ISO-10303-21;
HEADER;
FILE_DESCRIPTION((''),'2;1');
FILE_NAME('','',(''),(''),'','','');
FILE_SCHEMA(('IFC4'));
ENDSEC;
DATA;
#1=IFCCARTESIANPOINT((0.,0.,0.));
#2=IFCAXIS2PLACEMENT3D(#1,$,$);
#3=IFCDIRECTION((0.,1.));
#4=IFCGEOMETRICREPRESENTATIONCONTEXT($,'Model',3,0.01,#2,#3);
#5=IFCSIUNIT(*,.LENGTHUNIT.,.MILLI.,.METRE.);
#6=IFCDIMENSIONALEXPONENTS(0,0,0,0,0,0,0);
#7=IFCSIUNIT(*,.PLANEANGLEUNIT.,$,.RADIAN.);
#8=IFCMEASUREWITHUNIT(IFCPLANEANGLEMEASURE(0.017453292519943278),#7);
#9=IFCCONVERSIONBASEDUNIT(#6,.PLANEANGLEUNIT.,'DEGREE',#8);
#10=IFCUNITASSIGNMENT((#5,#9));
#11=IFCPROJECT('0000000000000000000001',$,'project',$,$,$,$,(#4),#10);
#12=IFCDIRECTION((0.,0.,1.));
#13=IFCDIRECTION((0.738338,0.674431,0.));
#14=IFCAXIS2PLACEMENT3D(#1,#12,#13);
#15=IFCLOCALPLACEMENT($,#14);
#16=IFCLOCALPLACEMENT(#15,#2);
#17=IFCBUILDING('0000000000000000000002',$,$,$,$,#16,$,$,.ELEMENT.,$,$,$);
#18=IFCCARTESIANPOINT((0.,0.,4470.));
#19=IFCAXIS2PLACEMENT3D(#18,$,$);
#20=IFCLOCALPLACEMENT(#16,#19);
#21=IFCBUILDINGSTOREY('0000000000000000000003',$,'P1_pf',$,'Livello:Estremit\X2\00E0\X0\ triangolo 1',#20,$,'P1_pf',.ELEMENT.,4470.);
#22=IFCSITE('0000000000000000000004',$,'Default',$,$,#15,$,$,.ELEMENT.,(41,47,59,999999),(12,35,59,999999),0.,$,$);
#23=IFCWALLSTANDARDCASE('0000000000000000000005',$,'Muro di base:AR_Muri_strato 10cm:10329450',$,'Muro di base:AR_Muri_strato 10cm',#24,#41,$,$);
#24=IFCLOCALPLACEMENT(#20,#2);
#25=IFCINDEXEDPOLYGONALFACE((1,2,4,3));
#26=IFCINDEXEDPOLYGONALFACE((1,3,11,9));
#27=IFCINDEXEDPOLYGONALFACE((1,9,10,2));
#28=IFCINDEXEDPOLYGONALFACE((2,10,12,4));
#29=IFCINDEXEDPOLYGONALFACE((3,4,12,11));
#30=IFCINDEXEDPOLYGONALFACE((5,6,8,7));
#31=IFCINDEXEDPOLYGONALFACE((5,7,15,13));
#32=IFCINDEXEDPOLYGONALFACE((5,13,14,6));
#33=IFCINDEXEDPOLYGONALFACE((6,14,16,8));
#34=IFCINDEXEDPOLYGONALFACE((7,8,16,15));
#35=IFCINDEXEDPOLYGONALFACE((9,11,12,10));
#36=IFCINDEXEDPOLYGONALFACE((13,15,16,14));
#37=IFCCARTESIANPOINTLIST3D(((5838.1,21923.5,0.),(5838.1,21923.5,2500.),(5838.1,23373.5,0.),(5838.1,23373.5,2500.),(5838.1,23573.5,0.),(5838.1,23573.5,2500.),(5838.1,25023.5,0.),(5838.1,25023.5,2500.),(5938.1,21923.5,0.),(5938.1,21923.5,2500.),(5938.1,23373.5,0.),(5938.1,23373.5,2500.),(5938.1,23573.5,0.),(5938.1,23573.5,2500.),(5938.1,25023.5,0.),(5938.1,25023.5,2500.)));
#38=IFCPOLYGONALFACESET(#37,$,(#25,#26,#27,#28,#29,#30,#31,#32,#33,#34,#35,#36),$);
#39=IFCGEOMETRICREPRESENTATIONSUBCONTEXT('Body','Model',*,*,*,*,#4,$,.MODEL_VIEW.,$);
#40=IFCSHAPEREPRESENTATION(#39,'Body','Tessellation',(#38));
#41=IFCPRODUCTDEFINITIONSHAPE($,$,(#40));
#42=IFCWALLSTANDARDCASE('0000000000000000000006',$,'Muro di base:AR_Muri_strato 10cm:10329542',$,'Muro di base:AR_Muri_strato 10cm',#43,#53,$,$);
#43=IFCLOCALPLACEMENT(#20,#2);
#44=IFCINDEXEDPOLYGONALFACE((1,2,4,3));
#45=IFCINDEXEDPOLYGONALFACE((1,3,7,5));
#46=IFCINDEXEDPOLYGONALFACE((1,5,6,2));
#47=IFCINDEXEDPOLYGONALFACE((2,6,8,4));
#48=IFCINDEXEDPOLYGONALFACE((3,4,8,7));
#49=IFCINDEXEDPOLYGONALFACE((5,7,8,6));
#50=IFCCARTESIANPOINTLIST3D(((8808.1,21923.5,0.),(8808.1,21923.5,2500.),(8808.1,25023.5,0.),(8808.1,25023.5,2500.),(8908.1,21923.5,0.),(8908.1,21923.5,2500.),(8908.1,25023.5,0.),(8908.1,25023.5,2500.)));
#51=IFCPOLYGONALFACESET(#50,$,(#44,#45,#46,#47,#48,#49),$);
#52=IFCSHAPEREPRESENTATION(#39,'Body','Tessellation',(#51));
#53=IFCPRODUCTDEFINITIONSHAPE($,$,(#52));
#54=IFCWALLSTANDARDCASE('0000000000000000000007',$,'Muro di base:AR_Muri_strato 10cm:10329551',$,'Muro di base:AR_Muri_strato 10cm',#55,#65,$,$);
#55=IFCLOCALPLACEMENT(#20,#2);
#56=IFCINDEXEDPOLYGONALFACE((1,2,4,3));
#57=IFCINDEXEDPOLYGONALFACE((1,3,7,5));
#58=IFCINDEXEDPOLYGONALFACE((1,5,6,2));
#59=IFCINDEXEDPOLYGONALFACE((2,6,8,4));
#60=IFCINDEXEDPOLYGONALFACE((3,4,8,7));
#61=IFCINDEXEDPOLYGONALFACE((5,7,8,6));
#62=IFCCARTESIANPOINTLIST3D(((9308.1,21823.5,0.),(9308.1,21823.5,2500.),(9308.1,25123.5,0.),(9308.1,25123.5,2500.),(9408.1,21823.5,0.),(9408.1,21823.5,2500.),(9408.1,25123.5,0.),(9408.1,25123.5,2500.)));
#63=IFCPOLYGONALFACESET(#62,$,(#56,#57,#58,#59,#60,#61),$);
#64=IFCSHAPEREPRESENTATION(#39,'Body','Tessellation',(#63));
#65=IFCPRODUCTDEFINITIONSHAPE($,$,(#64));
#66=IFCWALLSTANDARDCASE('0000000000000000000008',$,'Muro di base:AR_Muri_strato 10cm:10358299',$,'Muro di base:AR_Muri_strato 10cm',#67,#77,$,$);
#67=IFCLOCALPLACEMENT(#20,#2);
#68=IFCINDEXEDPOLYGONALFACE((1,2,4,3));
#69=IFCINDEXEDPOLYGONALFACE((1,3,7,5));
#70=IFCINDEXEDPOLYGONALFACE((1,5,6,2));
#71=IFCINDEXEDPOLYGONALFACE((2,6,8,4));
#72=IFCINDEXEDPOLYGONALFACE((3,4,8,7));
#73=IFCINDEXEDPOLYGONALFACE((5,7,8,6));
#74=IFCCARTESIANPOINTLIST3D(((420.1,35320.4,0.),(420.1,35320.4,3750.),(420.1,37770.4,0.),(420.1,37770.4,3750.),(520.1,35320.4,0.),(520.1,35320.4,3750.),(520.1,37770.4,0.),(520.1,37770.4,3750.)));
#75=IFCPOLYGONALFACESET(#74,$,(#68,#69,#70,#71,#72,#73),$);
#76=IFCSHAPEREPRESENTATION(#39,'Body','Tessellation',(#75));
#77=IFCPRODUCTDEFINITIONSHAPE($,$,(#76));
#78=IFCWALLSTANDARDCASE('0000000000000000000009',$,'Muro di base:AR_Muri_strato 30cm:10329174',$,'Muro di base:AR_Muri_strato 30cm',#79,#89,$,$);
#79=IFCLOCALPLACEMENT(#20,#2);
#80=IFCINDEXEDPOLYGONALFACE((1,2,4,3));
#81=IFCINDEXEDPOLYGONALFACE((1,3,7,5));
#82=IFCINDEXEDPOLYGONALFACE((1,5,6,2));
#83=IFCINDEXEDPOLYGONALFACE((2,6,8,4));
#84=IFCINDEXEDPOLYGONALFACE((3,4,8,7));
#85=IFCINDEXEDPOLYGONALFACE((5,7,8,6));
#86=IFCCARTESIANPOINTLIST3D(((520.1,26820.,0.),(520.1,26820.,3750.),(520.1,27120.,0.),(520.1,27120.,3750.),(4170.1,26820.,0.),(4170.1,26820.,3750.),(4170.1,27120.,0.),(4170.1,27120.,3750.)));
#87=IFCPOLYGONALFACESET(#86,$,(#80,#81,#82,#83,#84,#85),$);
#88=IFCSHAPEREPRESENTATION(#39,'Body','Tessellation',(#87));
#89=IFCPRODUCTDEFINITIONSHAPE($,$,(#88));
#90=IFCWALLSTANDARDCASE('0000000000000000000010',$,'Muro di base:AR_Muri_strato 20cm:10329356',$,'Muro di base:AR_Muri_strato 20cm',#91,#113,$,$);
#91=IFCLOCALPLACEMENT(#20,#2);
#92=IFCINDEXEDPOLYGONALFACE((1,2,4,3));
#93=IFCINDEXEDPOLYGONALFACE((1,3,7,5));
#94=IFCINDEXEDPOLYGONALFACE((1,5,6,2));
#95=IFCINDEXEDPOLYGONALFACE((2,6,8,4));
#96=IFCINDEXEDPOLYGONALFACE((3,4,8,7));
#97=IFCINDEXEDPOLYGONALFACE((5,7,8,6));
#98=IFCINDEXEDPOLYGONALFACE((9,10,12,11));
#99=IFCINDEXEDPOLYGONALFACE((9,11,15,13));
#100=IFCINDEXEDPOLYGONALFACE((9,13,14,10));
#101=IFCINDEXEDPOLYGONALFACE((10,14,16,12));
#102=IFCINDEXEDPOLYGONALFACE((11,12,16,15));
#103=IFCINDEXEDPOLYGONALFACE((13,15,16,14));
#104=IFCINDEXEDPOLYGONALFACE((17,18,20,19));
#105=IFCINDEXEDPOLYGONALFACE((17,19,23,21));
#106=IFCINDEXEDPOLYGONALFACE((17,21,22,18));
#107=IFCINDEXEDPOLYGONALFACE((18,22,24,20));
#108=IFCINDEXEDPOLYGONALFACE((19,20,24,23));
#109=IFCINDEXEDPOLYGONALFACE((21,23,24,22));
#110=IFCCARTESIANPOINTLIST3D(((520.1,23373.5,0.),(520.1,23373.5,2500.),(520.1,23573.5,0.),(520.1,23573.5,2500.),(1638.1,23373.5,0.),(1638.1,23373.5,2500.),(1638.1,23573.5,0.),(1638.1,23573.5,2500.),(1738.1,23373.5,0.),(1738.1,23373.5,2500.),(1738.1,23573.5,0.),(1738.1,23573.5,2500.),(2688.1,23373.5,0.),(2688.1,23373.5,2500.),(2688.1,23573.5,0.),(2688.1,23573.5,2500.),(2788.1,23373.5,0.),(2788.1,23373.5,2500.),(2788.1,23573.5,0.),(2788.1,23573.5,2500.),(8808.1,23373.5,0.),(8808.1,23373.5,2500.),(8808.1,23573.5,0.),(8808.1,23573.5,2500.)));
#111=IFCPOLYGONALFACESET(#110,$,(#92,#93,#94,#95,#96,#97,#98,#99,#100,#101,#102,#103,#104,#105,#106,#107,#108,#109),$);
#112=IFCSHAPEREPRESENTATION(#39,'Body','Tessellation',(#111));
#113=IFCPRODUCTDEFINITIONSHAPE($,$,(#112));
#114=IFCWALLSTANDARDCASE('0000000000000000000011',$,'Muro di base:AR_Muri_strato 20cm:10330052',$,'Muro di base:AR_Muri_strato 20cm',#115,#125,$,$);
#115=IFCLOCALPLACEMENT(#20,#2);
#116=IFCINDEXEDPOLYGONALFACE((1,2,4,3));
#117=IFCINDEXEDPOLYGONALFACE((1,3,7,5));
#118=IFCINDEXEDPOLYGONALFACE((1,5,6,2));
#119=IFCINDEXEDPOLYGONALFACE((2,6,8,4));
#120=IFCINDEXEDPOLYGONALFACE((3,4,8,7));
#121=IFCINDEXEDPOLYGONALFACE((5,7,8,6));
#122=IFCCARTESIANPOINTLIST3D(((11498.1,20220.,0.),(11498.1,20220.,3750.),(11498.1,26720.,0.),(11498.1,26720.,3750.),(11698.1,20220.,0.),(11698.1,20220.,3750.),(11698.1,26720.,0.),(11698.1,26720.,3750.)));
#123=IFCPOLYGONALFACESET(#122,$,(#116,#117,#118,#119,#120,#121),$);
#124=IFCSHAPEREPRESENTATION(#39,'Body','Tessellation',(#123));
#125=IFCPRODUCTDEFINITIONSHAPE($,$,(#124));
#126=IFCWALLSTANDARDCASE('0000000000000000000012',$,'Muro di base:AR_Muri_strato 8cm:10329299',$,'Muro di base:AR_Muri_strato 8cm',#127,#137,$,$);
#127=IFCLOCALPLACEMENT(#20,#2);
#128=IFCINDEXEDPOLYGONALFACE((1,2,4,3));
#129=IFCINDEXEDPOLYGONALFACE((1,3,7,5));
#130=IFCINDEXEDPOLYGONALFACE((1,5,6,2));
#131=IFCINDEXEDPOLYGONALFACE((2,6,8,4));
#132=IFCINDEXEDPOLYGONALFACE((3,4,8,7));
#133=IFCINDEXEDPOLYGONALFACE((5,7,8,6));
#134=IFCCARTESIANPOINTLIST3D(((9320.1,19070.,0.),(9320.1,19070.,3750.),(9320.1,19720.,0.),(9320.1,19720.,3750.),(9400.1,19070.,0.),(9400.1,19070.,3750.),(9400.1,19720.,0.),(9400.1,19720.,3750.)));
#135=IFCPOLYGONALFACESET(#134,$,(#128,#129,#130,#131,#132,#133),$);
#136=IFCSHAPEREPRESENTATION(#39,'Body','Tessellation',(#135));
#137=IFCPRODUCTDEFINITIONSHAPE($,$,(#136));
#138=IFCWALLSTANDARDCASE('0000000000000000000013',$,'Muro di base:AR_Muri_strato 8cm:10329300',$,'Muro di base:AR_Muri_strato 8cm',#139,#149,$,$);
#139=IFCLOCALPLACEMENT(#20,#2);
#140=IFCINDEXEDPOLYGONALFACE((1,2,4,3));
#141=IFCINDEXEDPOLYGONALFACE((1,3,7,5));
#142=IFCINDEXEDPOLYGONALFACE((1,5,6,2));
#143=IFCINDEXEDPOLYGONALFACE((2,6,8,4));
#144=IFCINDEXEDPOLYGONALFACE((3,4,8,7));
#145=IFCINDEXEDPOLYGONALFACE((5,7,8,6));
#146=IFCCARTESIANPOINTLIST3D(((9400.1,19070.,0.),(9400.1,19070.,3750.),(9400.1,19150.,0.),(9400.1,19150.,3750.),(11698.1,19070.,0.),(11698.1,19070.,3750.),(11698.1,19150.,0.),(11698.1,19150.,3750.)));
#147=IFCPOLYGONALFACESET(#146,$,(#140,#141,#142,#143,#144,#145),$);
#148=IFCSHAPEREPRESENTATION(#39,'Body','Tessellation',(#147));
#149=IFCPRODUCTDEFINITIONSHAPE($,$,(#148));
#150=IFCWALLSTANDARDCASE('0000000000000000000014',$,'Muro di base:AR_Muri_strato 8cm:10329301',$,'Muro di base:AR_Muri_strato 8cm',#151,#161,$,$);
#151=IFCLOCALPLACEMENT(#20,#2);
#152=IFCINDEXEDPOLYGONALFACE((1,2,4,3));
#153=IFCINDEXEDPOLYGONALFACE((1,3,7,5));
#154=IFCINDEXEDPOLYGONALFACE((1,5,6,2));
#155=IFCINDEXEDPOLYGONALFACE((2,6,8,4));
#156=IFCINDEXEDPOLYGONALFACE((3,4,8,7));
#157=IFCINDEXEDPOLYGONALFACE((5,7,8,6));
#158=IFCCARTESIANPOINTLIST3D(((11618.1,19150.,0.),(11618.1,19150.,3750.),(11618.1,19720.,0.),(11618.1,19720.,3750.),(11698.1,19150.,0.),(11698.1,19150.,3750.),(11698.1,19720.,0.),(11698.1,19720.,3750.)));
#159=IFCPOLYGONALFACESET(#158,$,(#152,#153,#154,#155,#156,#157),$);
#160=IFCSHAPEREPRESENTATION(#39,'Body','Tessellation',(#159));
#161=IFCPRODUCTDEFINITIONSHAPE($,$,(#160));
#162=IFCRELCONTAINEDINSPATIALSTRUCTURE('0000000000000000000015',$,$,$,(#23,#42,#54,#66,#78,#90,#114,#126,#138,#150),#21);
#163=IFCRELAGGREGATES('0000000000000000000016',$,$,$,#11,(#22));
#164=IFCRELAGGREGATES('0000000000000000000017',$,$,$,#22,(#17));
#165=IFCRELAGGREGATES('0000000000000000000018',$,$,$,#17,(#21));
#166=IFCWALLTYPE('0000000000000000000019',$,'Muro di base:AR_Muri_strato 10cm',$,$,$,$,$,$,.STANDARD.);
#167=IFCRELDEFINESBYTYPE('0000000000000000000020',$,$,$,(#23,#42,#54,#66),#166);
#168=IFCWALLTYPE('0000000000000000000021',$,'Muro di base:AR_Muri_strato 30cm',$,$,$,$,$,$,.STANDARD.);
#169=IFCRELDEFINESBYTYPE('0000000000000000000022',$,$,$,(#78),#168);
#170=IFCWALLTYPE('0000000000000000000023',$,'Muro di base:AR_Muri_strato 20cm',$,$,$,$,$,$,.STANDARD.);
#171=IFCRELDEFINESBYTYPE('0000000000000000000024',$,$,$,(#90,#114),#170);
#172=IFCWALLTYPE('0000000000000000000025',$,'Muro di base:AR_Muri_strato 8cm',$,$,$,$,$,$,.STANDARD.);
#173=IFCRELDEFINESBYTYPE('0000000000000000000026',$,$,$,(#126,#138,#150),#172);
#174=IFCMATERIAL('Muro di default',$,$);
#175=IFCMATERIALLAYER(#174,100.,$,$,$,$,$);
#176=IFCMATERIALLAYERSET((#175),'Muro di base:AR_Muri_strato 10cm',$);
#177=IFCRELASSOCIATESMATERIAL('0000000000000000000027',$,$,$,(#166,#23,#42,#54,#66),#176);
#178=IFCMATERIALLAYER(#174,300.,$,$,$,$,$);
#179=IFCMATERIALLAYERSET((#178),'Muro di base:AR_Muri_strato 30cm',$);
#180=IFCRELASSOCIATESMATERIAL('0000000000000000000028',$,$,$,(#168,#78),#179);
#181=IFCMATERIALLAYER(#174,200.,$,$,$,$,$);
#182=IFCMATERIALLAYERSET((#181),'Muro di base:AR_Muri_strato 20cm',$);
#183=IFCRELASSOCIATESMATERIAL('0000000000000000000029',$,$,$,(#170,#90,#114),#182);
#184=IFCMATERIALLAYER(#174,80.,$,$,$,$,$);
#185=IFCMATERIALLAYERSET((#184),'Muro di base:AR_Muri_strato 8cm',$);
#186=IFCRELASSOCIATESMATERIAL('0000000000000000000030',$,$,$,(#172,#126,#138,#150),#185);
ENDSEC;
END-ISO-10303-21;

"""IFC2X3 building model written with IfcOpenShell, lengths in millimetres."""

from ifc_helpers import new_model, entity, si_unit, converted_unit, direction, frame, frame_2d, origin, place, context, subcontext, project, spatial, rectangle, extrude, material, layer, layer_set, layer_usage, type_object, element, save


model = new_model("IFC2X3")

# Units and contexts
model_context = context("Model", 3, precision=0.01, world=origin(), true_north=direction((0.0, 1.0)))
body_context = subcontext(model_context, "Body", "Model", "MODEL_VIEW")
ifc_project = project(units=[si_unit("LENGTHUNIT", "METRE", prefix="MILLI"), converted_unit("PLANEANGLEUNIT", "DEGREE", entity("IfcPlaneAngleMeasure", 0.017453292519943278), si_unit("PLANEANGLEUNIT", "RADIAN"), dimensions=[0, 0, 0, 0, 0, 0, 0])], contexts=[model_context])

# Site, building, storey
site_placement = place(None, frame((0.0, 0.0, 0.0), z_axis=(0.0, 0.0, 1.0), x_axis=(0.738338, 0.674431, 0.0)))
site = spatial("IfcSite", under=ifc_project, at=site_placement, Name="Default", CompositionType="ELEMENT", RefLatitude=(41, 47, 59, 999999), RefLongitude=(12, 35, 59, 999999), RefElevation=0.0)
building_placement = place(site_placement, origin())
building = spatial("IfcBuilding", under=site, at=building_placement, CompositionType="ELEMENT")
storey_placement = place(building_placement, frame((0.0, 0.0, 4470.0)))
storey = spatial("IfcBuildingStorey", under=building, at=storey_placement, Name="P1_pf", ObjectType="Livello:Estremità triangolo 1", LongName="P1_pf", CompositionType="ELEMENT", Elevation=4470.0)

# Shared definitions
ifc_material_1 = material(Name="Muro di default")
ifc_layer_1 = layer(ifc_material_1, 100.0)
ifc_layer_set_1 = layer_set([ifc_layer_1], Name="Muro di base:AR_Muri_strato 10cm")
wall_type_1 = type_object("IfcWallType", Name="Muro di base:AR_Muri_strato 10cm", PredefinedType="STANDARD", material=ifc_layer_set_1)

# Wall, opening
ifc_layer_usage_1 = layer_usage(ifc_layer_set_1, "AXIS2", "NEGATIVE", 50.0)
wall_1_placement = place(storey_placement, frame((5888.1, 21923.5, 0.0), z_axis=(0.0, 0.0, 1.0), x_axis=(0.0, 1.0, 0.0)))
wall_1 = element("IfcWallStandardCase", 1, at=wall_1_placement, inside=storey, type_object=wall_type_1, material=ifc_layer_usage_1, Name="Muro di base:AR_Muri_strato 10cm:10329450", ObjectType="Muro di base:AR_Muri_strato 10cm", context=body_context, shape_type="SweptSolid", body=[
    extrude(rectangle(XDim=3100.0, YDim=100.0, at=frame_2d((1550.0, 0.0), x_axis=(-1.0, 0.0))), origin(), (0.0, 0.0, 1.0), 2500.0),
])
opening_1_placement = place(storey_placement, frame((5888.1, 21923.5, 0.0), z_axis=(0.0, 0.0, 1.0), x_axis=(0.0, 1.0, 0.0)))
element("IfcOpeningElement", 2, at=opening_1_placement, cuts=wall_1, ObjectType="Opening", context=body_context, shape_type="SweptSolid", body=[
    extrude(rectangle(XDim=2500.0, YDim=100.0, at=frame_2d((0.0, 0.0), x_axis=(1.0, 0.0))), frame((1450.0, 0.0, 1250.0), z_axis=(1.0, 0.0, 0.0), x_axis=(0.0, 0.0, -1.0)), (0.0, 0.0, 1.0), 200.0),
])

# Walls
ifc_layer_usage_2 = layer_usage(ifc_layer_set_1, "AXIS2", "NEGATIVE", 50.0)
wall_2_placement = place(storey_placement, frame((8858.1, 21923.5, 0.0), z_axis=(0.0, 0.0, 1.0), x_axis=(0.0, 1.0, 0.0)))
element("IfcWallStandardCase", 3, at=wall_2_placement, inside=storey, type_object=wall_type_1, material=ifc_layer_usage_2, Name="Muro di base:AR_Muri_strato 10cm:10329542", ObjectType="Muro di base:AR_Muri_strato 10cm", context=body_context, shape_type="SweptSolid", body=[
    extrude(rectangle(XDim=3100.0, YDim=100.0, at=frame_2d((1550.0, 0.0), x_axis=(-1.0, 0.0))), origin(), (0.0, 0.0, 1.0), 2500.0),
])
ifc_layer_usage_3 = layer_usage(ifc_layer_set_1, "AXIS2", "NEGATIVE", 50.0)
wall_3_placement = place(storey_placement, frame((9358.1, 21823.5, 0.0), z_axis=(0.0, 0.0, 1.0), x_axis=(0.0, 1.0, 0.0)))
element("IfcWallStandardCase", 4, at=wall_3_placement, inside=storey, type_object=wall_type_1, material=ifc_layer_usage_3, Name="Muro di base:AR_Muri_strato 10cm:10329551", ObjectType="Muro di base:AR_Muri_strato 10cm", context=body_context, shape_type="SweptSolid", body=[
    extrude(rectangle(XDim=3300.0, YDim=100.0, at=frame_2d((1650.0, 0.0), x_axis=(-1.0, 0.0))), origin(), (0.0, 0.0, 1.0), 2500.0),
])
ifc_layer_usage_4 = layer_usage(ifc_layer_set_1, "AXIS2", "NEGATIVE", 50.0)
wall_4_placement = place(storey_placement, frame((470.1, 35320.4, 0.0), z_axis=(0.0, 0.0, 1.0), x_axis=(0.0, 1.0, 0.0)))
element("IfcWallStandardCase", 5, at=wall_4_placement, inside=storey, type_object=wall_type_1, material=ifc_layer_usage_4, Name="Muro di base:AR_Muri_strato 10cm:10358299", ObjectType="Muro di base:AR_Muri_strato 10cm", context=body_context, shape_type="SweptSolid", body=[
    extrude(rectangle(XDim=2450.0, YDim=100.0, at=frame_2d((1225.0, 0.0), x_axis=(-1.0, 0.0))), origin(), (0.0, 0.0, 1.0), 3750.0),
])
ifc_layer_2 = layer(ifc_material_1, 300.0)
ifc_layer_set_2 = layer_set([ifc_layer_2], Name="Muro di base:AR_Muri_strato 30cm")
ifc_layer_usage_5 = layer_usage(ifc_layer_set_2, "AXIS2", "NEGATIVE", 150.0)
wall_type_2 = type_object("IfcWallType", Name="Muro di base:AR_Muri_strato 30cm", PredefinedType="STANDARD", material=ifc_layer_set_2)
wall_5_placement = place(storey_placement, frame((4170.1, 26970.0, 0.0), z_axis=(0.0, 0.0, 1.0), x_axis=(-1.0, 0.0, 0.0)))
element("IfcWallStandardCase", 6, at=wall_5_placement, inside=storey, type_object=wall_type_2, material=ifc_layer_usage_5, Name="Muro di base:AR_Muri_strato 30cm:10329174", ObjectType="Muro di base:AR_Muri_strato 30cm", context=body_context, shape_type="SweptSolid", body=[
    extrude(rectangle(XDim=3650.0, YDim=300.0, at=frame_2d((1825.0, 0.0), x_axis=(-1.0, 0.0))), origin(), (0.0, 0.0, 1.0), 3750.0),
])

# Wall, openings
ifc_layer_3 = layer(ifc_material_1, 200.0)
ifc_layer_set_3 = layer_set([ifc_layer_3], Name="Muro di base:AR_Muri_strato 20cm")
ifc_layer_usage_6 = layer_usage(ifc_layer_set_3, "AXIS2", "NEGATIVE", 100.0)
wall_type_3 = type_object("IfcWallType", Name="Muro di base:AR_Muri_strato 20cm", PredefinedType="STANDARD", material=ifc_layer_set_3)
wall_6_placement = place(storey_placement, frame((8808.1, 23473.5, 0.0), z_axis=(0.0, 0.0, 1.0), x_axis=(-1.0, 0.0, 0.0)))
wall_6 = element("IfcWallStandardCase", 7, at=wall_6_placement, inside=storey, type_object=wall_type_3, material=ifc_layer_usage_6, Name="Muro di base:AR_Muri_strato 20cm:10329356", ObjectType="Muro di base:AR_Muri_strato 20cm", context=body_context, shape_type="SweptSolid", body=[
    extrude(rectangle(XDim=8288.0, YDim=200.0, at=frame_2d((4144.0, 0.0), x_axis=(-1.0, 0.0))), origin(), (0.0, 0.0, 1.0), 2500.0),
])
opening_2_placement = place(storey_placement, frame((8808.1, 23473.5, 0.0), z_axis=(0.0, 0.0, 1.0), x_axis=(-1.0, 0.0, 0.0)))
element("IfcOpeningElement", 8, at=opening_2_placement, cuts=wall_6, ObjectType="Opening", context=body_context, shape_type="SweptSolid", body=[
    extrude(rectangle(XDim=2500.0, YDim=200.0, at=frame_2d((0.0, 0.0), x_axis=(1.0, 0.0))), frame((6120.0, 0.0, 1250.0), z_axis=(-1.0, 0.0, 0.0), x_axis=(0.0, 0.0, 1.0)), (0.0, 0.0, 1.0), 100.0),
])
opening_3_placement = place(storey_placement, frame((8808.1, 23473.5, 0.0), z_axis=(0.0, 0.0, 1.0), x_axis=(-1.0, 0.0, 0.0)))
element("IfcOpeningElement", 9, at=opening_3_placement, cuts=wall_6, ObjectType="Opening", context=body_context, shape_type="SweptSolid", body=[
    extrude(rectangle(XDim=2500.0, YDim=200.0, at=frame_2d((0.0, 0.0), x_axis=(1.0, 0.0))), frame((7170.0, 0.0, 1250.0), z_axis=(-1.0, 0.0, 0.0), x_axis=(0.0, 0.0, 1.0)), (0.0, 0.0, 1.0), 100.0),
])

# Walls
ifc_layer_usage_7 = layer_usage(ifc_layer_set_3, "AXIS2", "NEGATIVE", 100.0)
wall_7_placement = place(storey_placement, frame((11598.1, 26720.0, 0.0), z_axis=(0.0, 0.0, 1.0), x_axis=(0.0, -1.0, 0.0)))
element("IfcWallStandardCase", 10, at=wall_7_placement, inside=storey, type_object=wall_type_3, material=ifc_layer_usage_7, Name="Muro di base:AR_Muri_strato 20cm:10330052", ObjectType="Muro di base:AR_Muri_strato 20cm", context=body_context, shape_type="SweptSolid", body=[
    extrude(rectangle(XDim=6500.0, YDim=200.0, at=frame_2d((3250.0, 0.0), x_axis=(-1.0, 0.0))), origin(), (0.0, 0.0, 1.0), 3750.0),
])
ifc_layer_4 = layer(ifc_material_1, 80.0)
ifc_layer_set_4 = layer_set([ifc_layer_4], Name="Muro di base:AR_Muri_strato 8cm")
ifc_layer_usage_8 = layer_usage(ifc_layer_set_4, "AXIS2", "NEGATIVE", 40.0)
wall_type_4 = type_object("IfcWallType", Name="Muro di base:AR_Muri_strato 8cm", PredefinedType="STANDARD", material=ifc_layer_set_4)
wall_8_placement = place(storey_placement, frame((9360.1, 19720.0, 0.0), z_axis=(0.0, 0.0, 1.0), x_axis=(0.0, -1.0, 0.0)))
element("IfcWallStandardCase", 11, at=wall_8_placement, inside=storey, type_object=wall_type_4, material=ifc_layer_usage_8, Name="Muro di base:AR_Muri_strato 8cm:10329299", ObjectType="Muro di base:AR_Muri_strato 8cm", context=body_context, shape_type="SweptSolid", body=[
    extrude(rectangle(XDim=650.0, YDim=80.0, at=frame_2d((325.0, 0.0), x_axis=(-1.0, 0.0))), origin(), (0.0, 0.0, 1.0), 3750.0),
])
ifc_layer_usage_9 = layer_usage(ifc_layer_set_4, "AXIS2", "NEGATIVE", 40.0)
wall_9_placement = place(storey_placement, frame((9400.1, 19110.0, 0.0)))
element("IfcWallStandardCase", 12, at=wall_9_placement, inside=storey, type_object=wall_type_4, material=ifc_layer_usage_9, Name="Muro di base:AR_Muri_strato 8cm:10329300", ObjectType="Muro di base:AR_Muri_strato 8cm", context=body_context, shape_type="SweptSolid", body=[
    extrude(rectangle(XDim=2298.0, YDim=80.0, at=frame_2d((1149.0, 0.0), x_axis=(-1.0, 0.0))), origin(), (0.0, 0.0, 1.0), 3750.0),
])
ifc_layer_usage_10 = layer_usage(ifc_layer_set_4, "AXIS2", "NEGATIVE", 40.0)
wall_10_placement = place(storey_placement, frame((11658.1, 19150.0, 0.0), z_axis=(0.0, 0.0, 1.0), x_axis=(0.0, 1.0, 0.0)))
element("IfcWallStandardCase", 13, at=wall_10_placement, inside=storey, type_object=wall_type_4, material=ifc_layer_usage_10, Name="Muro di base:AR_Muri_strato 8cm:10329301", ObjectType="Muro di base:AR_Muri_strato 8cm", context=body_context, shape_type="SweptSolid", body=[
    extrude(rectangle(XDim=570.0, YDim=80.0, at=frame_2d((285.0, 0.0), x_axis=(-1.0, 0.0))), origin(), (0.0, 0.0, 1.0), 3750.0),
])

save(model, "model.ifc")
